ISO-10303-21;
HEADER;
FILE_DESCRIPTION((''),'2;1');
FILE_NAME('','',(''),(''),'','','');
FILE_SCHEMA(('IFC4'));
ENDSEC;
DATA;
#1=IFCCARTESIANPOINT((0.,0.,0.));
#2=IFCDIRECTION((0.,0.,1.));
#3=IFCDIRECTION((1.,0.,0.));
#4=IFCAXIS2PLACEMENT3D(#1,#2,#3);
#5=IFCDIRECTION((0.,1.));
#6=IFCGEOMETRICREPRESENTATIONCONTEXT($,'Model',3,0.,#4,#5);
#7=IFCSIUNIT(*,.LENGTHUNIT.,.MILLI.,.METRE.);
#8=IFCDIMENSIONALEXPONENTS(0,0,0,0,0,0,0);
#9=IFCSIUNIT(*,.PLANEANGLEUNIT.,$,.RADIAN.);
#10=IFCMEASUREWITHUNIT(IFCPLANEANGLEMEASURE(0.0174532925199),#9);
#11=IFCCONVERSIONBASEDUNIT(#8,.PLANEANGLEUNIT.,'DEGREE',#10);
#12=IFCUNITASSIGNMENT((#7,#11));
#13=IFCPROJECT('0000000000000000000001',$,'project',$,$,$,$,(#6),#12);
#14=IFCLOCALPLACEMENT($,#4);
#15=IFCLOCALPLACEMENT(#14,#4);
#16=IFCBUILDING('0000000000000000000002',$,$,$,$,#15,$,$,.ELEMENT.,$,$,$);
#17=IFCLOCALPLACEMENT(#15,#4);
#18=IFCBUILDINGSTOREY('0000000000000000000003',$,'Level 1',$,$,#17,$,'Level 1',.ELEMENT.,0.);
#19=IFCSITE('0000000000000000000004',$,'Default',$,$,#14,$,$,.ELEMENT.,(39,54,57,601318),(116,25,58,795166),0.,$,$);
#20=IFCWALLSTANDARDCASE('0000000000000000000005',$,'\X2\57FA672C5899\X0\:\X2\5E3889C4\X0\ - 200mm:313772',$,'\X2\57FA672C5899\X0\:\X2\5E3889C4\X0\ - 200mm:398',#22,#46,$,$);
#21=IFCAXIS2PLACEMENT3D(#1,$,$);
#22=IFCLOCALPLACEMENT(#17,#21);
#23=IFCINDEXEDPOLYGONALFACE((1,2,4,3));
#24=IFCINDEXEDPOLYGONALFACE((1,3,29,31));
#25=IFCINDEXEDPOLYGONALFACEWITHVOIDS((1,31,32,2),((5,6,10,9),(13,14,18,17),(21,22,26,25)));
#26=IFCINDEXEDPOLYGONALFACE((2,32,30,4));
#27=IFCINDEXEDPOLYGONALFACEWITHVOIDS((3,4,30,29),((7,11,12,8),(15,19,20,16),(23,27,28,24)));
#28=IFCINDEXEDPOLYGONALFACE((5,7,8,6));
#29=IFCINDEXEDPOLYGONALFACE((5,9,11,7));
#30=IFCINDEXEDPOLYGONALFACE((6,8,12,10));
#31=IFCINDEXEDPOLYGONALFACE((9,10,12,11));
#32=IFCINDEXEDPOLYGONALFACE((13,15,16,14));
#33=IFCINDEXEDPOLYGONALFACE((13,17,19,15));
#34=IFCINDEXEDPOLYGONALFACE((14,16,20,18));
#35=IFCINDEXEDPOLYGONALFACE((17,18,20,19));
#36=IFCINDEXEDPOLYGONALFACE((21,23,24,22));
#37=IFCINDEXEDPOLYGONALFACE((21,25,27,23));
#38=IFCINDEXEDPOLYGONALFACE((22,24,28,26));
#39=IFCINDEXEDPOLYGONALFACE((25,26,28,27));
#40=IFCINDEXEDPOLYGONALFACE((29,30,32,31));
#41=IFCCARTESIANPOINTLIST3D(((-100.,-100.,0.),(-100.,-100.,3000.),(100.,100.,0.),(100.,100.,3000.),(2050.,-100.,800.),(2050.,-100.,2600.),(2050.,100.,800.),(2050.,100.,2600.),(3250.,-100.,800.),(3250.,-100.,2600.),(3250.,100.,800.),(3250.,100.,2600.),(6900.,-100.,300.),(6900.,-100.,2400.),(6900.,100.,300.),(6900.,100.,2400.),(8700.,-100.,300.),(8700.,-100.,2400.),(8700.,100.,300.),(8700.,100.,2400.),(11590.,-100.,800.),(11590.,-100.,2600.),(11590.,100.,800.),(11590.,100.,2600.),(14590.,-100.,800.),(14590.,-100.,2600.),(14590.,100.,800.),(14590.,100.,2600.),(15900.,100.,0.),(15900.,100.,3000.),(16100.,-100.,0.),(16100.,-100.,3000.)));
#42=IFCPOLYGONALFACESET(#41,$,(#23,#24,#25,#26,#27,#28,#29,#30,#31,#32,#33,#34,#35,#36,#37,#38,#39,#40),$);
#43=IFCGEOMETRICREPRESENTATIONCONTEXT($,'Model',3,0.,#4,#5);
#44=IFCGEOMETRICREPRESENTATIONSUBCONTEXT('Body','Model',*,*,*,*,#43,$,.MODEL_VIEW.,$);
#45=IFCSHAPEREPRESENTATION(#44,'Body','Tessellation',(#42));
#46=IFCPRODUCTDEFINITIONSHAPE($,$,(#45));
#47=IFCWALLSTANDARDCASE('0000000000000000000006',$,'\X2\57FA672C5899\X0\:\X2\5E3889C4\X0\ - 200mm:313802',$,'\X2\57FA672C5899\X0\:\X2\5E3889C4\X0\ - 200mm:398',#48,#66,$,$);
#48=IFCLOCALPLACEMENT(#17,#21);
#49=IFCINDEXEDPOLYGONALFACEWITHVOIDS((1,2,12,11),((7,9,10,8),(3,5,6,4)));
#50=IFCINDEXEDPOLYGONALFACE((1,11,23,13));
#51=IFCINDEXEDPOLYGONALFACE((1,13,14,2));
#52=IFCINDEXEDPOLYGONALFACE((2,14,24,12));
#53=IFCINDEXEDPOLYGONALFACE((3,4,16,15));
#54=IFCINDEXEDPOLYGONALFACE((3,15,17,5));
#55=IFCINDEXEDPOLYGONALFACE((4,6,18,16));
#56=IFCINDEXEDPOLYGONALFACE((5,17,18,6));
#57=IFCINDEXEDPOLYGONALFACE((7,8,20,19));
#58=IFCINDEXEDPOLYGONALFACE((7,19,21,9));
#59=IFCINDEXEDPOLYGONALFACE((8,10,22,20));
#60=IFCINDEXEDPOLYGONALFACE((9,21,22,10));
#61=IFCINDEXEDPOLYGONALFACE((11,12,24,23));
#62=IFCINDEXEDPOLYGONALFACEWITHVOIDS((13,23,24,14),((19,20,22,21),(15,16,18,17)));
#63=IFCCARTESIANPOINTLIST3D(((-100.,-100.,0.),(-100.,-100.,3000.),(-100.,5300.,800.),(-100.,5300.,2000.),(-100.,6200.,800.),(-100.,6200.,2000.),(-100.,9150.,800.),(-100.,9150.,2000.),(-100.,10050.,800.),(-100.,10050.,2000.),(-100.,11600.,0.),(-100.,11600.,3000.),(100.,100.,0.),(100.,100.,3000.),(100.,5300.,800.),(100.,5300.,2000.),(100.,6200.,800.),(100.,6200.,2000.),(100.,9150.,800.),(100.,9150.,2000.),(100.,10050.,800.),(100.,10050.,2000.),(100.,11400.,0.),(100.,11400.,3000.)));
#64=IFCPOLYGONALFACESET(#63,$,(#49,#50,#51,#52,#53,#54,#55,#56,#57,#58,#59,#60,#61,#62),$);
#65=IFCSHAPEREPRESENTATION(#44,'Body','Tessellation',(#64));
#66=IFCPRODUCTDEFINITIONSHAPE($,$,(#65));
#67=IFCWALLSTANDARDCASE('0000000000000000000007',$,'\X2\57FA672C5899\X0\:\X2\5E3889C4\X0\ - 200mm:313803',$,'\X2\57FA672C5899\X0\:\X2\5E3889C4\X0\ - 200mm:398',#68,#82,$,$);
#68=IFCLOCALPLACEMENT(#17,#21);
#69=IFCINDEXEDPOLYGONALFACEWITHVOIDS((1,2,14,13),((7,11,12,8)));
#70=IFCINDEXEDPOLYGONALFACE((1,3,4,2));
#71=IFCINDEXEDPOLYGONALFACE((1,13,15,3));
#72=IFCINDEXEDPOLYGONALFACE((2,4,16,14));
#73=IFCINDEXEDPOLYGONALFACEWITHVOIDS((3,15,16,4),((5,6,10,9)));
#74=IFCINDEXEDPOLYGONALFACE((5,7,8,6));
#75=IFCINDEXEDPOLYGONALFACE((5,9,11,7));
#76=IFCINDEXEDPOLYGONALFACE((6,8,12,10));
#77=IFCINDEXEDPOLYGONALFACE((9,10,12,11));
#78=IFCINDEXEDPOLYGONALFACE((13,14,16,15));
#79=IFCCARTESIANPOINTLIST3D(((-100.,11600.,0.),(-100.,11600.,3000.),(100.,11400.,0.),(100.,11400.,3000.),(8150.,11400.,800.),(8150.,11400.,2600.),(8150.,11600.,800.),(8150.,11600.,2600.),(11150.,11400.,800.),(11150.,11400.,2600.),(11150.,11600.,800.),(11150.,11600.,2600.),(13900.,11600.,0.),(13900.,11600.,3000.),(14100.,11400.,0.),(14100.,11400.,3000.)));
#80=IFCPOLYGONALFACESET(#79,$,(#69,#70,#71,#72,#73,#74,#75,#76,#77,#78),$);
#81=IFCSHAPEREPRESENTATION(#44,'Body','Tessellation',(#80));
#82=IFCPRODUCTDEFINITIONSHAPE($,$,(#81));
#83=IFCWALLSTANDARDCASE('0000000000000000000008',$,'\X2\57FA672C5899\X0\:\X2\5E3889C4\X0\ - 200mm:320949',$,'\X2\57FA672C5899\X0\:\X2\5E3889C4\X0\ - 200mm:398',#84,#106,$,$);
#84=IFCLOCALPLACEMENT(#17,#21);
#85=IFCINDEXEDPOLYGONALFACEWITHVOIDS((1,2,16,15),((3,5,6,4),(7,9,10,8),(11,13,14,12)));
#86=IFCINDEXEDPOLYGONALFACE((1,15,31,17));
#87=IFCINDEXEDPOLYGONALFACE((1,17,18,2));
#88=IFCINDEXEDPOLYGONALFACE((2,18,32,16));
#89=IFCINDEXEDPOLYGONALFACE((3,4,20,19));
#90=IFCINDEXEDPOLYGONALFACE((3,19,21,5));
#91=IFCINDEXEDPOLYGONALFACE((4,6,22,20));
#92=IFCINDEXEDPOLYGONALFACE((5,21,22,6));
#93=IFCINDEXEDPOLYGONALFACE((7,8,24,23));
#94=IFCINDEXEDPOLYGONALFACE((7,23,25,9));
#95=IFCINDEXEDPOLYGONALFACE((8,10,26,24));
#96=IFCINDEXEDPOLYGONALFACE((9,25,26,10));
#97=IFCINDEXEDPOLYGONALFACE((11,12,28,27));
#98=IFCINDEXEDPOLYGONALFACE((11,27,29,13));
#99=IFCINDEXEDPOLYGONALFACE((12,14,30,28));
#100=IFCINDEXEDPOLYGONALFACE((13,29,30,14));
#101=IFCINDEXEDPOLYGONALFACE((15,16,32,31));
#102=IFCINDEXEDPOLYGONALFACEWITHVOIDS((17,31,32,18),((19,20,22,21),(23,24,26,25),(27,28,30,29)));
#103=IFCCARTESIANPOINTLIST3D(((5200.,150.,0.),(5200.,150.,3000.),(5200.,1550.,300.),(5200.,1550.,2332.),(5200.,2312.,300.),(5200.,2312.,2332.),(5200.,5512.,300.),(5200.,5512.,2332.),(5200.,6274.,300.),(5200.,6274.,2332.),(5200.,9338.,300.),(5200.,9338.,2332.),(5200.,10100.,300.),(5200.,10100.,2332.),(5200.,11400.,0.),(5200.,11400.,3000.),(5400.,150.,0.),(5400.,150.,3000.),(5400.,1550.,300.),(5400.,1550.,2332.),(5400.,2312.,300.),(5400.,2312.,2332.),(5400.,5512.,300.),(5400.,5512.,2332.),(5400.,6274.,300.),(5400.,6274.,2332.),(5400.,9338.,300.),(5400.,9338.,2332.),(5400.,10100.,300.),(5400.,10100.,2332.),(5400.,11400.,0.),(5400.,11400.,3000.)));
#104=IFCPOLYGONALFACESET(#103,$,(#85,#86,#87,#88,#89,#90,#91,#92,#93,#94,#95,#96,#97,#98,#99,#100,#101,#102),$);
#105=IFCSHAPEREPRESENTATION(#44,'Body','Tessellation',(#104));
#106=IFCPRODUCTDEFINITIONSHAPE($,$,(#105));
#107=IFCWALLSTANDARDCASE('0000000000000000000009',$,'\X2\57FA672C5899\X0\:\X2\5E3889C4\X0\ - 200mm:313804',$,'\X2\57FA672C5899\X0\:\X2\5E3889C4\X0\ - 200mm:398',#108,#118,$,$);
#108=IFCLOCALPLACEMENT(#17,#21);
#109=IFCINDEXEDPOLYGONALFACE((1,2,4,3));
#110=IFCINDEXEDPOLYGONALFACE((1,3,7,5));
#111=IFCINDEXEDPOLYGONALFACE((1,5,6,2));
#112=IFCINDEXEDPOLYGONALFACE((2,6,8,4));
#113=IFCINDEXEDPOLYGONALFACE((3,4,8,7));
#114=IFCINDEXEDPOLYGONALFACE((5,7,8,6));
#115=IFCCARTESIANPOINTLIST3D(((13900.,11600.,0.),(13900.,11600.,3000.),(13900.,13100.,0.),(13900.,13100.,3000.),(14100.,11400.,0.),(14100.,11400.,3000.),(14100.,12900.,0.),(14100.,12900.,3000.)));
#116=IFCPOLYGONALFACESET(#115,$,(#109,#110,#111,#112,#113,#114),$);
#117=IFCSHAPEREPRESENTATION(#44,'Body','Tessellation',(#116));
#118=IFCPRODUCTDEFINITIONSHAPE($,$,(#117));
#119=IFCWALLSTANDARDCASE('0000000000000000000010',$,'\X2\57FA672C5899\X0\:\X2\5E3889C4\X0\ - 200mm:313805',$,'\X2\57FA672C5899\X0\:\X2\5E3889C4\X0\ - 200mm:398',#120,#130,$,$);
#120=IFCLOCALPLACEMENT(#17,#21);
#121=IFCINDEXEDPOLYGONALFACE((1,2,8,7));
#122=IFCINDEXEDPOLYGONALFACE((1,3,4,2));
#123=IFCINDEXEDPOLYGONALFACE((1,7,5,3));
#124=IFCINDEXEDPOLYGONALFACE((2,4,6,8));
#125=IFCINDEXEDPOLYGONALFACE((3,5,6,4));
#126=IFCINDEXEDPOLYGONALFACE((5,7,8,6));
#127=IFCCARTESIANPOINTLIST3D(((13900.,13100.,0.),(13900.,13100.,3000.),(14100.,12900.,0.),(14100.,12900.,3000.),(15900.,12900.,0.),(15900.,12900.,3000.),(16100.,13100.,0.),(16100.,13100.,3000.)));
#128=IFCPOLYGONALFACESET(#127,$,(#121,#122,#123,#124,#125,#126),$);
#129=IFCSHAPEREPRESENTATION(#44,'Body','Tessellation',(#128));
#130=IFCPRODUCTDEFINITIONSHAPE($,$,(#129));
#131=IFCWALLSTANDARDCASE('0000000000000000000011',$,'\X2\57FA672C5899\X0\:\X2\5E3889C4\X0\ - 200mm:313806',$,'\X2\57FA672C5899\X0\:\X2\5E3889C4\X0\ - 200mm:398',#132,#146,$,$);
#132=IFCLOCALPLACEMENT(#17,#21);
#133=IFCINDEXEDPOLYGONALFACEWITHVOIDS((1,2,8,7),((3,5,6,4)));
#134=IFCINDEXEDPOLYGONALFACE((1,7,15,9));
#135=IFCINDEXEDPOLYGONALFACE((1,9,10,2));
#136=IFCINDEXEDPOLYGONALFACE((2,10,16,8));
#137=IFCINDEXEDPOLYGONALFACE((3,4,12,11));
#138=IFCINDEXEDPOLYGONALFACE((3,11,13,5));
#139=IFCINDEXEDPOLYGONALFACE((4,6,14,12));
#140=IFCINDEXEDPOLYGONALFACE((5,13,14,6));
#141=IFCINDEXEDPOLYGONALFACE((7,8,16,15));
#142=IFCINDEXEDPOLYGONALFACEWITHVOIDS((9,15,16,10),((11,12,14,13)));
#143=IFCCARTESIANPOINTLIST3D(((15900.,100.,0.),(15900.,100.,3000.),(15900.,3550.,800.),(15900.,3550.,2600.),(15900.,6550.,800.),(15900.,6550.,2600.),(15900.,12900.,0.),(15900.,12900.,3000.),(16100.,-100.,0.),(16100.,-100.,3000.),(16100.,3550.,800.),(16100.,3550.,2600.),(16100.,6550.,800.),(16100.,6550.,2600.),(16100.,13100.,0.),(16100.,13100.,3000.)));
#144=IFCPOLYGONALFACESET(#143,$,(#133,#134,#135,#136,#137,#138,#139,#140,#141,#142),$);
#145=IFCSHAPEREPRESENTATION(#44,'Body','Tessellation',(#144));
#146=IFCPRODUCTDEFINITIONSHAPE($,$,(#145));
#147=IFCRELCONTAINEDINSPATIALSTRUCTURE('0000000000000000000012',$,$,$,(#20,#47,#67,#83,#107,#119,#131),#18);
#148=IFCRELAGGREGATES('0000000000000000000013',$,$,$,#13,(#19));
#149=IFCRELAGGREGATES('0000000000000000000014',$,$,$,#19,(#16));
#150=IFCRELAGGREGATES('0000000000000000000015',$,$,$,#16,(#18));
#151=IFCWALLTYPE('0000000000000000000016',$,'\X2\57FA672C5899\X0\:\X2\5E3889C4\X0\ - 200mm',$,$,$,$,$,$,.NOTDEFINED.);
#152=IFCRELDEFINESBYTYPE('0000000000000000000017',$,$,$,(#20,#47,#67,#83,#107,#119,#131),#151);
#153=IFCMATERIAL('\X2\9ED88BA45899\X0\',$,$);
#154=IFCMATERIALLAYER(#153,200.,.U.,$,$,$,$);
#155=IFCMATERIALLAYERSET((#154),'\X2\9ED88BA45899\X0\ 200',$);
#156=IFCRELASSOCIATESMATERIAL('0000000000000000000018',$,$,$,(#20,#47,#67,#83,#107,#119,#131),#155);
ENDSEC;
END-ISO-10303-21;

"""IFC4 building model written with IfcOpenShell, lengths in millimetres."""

from ifc_helpers import new_model, entity, si_unit, converted_unit, direction, frame, origin_with_axes, place, context, subcontext, project, spatial, polyline, outline, extrude, material, layer, layer_set, layer_usage, type_object, element, save


model = new_model("IFC4")

# Units and contexts
model_context_1 = context("Model", 3, precision=0.0, world=origin_with_axes(), true_north=direction((0.0, 1.0)))
model_context_2 = context("Model", 3, precision=0.0, world=origin_with_axes(), true_north=direction((0.0, 1.0)))
body_context = subcontext(model_context_2, "Body", "Model", "MODEL_VIEW")
ifc_project = project(units=[si_unit("LENGTHUNIT", "METRE", prefix="MILLI"), converted_unit("PLANEANGLEUNIT", "DEGREE", entity("IfcPlaneAngleMeasure", 0.0174532925199), si_unit("PLANEANGLEUNIT", "RADIAN"), dimensions=[0, 0, 0, 0, 0, 0, 0])], contexts=[model_context_1])

# Site, building, storey
site_placement = place(None, origin_with_axes())
site = spatial("IfcSite", under=ifc_project, at=site_placement, Name="Default", CompositionType="ELEMENT", RefLatitude=(39, 54, 57, 601318), RefLongitude=(116, 25, 58, 795166), RefElevation=0.0)
building_placement = place(site_placement, origin_with_axes())
building = spatial("IfcBuilding", under=site, at=building_placement, CompositionType="ELEMENT")
storey_placement = place(building_placement, origin_with_axes())
storey = spatial("IfcBuildingStorey", under=building, at=storey_placement, Name="Level 1", LongName="Level 1", CompositionType="ELEMENT", Elevation=0.0)

# Walls, openings
ifc_material = material(Name="默认墙")
ifc_layer = layer(ifc_material, 200.0, ventilated="UNKNOWN")
ifc_layer_set = layer_set([ifc_layer], Name="默认墙 200")
ifc_layer_usage_1 = layer_usage(ifc_layer_set, "AXIS2", "POSITIVE", -100.0)
wall_type = type_object("IfcWallType", Name="基本墙:常规 - 200mm", PredefinedType="NOTDEFINED")
wall_1_placement = place(storey_placement, frame((16000.0, 0.0, 0.0), z_axis=(0.0, 0.0, 1.0), x_axis=(-1.0, 0.0, 0.0)))
wall_1 = element("IfcWallStandardCase", 1, at=wall_1_placement, inside=storey, type_object=wall_type, material=ifc_layer_usage_1, Name="基本墙:常规 - 200mm:313772", ObjectType="基本墙:常规 - 200mm:398", context=body_context, shape_type="SweptSolid", body=[
    extrude(outline(polyline([(100.0, -100.0), (15900.0, -100.0), (16100.0, 100.0), (-100.0, 100.0), (100.0, -100.0)])), origin_with_axes(), (0.0, 0.0, 1.0), 3000.0),
])
opening_1_placement = place(wall_1_placement, frame((13350.0, 0.0, 800.0), z_axis=(0.0, 0.0, 1.0), x_axis=(1.0, 0.0, 0.0)))
element("IfcOpeningElement", 2, at=opening_1_placement, cuts=wall_1, context=body_context, shape_type="SweptSolid", body=[
    extrude(outline(polyline([(-600.0, 0.0), (-600.0, -1800.0), (600.0, -1800.0), (600.0, 0.0), (-600.0, 0.0)])), frame((0.0, -100.0, 0.0), z_axis=(0.0, 1.0, 0.0), x_axis=(1.0, 0.0, 0.0)), (0.0, 0.0, 1.0), 200.0),
])
opening_2_placement = place(wall_1_placement, frame((2910.0, 0.0, 800.0), z_axis=(0.0, 0.0, 1.0), x_axis=(1.0, 0.0, 0.0)))
element("IfcOpeningElement", 3, at=opening_2_placement, cuts=wall_1, context=body_context, shape_type="SweptSolid", body=[
    extrude(outline(polyline([(-1500.0, 0.0), (-1500.0, -1800.0), (1500.0, -1800.0), (1500.0, 0.0), (-1500.0, 0.0)])), frame((0.0, -100.0, 0.0), z_axis=(0.0, 1.0, 0.0), x_axis=(1.0, 0.0, 0.0)), (0.0, 0.0, 1.0), 200.0),
])
opening_3_placement = place(wall_1_placement, frame((8200.0, 0.0, 300.0), z_axis=(0.0, 0.0, 1.0), x_axis=(1.0, 0.0, 0.0)))
element("IfcOpeningElement", 4, at=opening_3_placement, cuts=wall_1, context=body_context, shape_type="SweptSolid", body=[
    extrude(outline(polyline([(-900.0, 0.0), (-900.0, -2100.0), (900.0, -2100.0), (900.0, 0.0), (-900.0, 0.0)])), frame((0.0, -100.0, 0.0), z_axis=(0.0, 1.0, 0.0), x_axis=(1.0, 0.0, 0.0)), (0.0, 0.0, 1.0), 200.0),
])
ifc_layer_usage_2 = layer_usage(ifc_layer_set, "AXIS2", "POSITIVE", -100.0)
wall_2_placement = place(storey_placement, frame((0.0, 0.0, 0.0), z_axis=(0.0, 0.0, 1.0), x_axis=(0.0, 1.0, 0.0)))
wall_2 = element("IfcWallStandardCase", 5, at=wall_2_placement, inside=storey, type_object=wall_type, material=ifc_layer_usage_2, Name="基本墙:常规 - 200mm:313802", ObjectType="基本墙:常规 - 200mm:398", context=body_context, shape_type="SweptSolid", body=[
    extrude(outline(polyline([(100.0, -100.0), (11400.0, -100.0), (11600.0, 100.0), (-100.0, 100.0), (100.0, -100.0)])), origin_with_axes(), (0.0, 0.0, 1.0), 3000.0),
])
opening_4_placement = place(wall_2_placement, frame((5750.0, 0.0, 800.0), z_axis=(0.0, 0.0, 1.0), x_axis=(1.0, 0.0, 0.0)))
element("IfcOpeningElement", 6, at=opening_4_placement, cuts=wall_2, context=body_context, shape_type="SweptSolid", body=[
    extrude(outline(polyline([(450.0, -1200.0), (450.0, 0.0), (-450.0, 0.0), (-450.0, -1200.0), (450.0, -1200.0)])), frame((0.0, 100.0, 0.0), z_axis=(0.0, -1.0, 0.0), x_axis=(-1.0, 0.0, 0.0)), (0.0, 0.0, 1.0), 200.0),
])
opening_5_placement = place(wall_2_placement, frame((9600.0, 0.0, 800.0), z_axis=(0.0, 0.0, 1.0), x_axis=(1.0, 0.0, 0.0)))
element("IfcOpeningElement", 7, at=opening_5_placement, cuts=wall_2, context=body_context, shape_type="SweptSolid", body=[
    extrude(outline(polyline([(450.0, -1200.0), (450.0, 0.0), (-450.0, 0.0), (-450.0, -1200.0), (450.0, -1200.0)])), frame((0.0, 100.0, 0.0), z_axis=(0.0, -1.0, 0.0), x_axis=(-1.0, 0.0, 0.0)), (0.0, 0.0, 1.0), 200.0),
])

# Wall, opening
ifc_layer_usage_3 = layer_usage(ifc_layer_set, "AXIS2", "POSITIVE", -100.0)
wall_3_placement = place(storey_placement, frame((0.0, 11500.0, 0.0), z_axis=(0.0, 0.0, 1.0), x_axis=(1.0, 0.0, 0.0)))
wall_3 = element("IfcWallStandardCase", 8, at=wall_3_placement, inside=storey, type_object=wall_type, material=ifc_layer_usage_3, Name="基本墙:常规 - 200mm:313803", ObjectType="基本墙:常规 - 200mm:398", context=body_context, shape_type="SweptSolid", body=[
    extrude(outline(polyline([(100.0, -100.0), (14100.0, -100.0), (13900.0, 100.0), (-100.0, 100.0), (100.0, -100.0)])), origin_with_axes(), (0.0, 0.0, 1.0), 3000.0),
])
opening_6_placement = place(wall_3_placement, frame((9650.0, 0.0, 800.0), z_axis=(0.0, 0.0, 1.0), x_axis=(1.0, 0.0, 0.0)))
element("IfcOpeningElement", 9, at=opening_6_placement, cuts=wall_3, context=body_context, shape_type="SweptSolid", body=[
    extrude(outline(polyline([(-1500.0, 0.0), (-1500.0, -1800.0), (1500.0, -1800.0), (1500.0, 0.0), (-1500.0, 0.0)])), frame((0.0, -100.0, 0.0), z_axis=(0.0, 1.0, 0.0), x_axis=(1.0, 0.0, 0.0)), (0.0, 0.0, 1.0), 200.0),
])

# Wall, openings
ifc_layer_usage_4 = layer_usage(ifc_layer_set, "AXIS2", "POSITIVE", -100.0)
wall_4_placement = place(storey_placement, frame((5300.0, 11500.0, 0.0), z_axis=(0.0, 0.0, 1.0), x_axis=(0.0, -1.0, 0.0)))
wall_4 = element("IfcWallStandardCase", 10, at=wall_4_placement, inside=storey, type_object=wall_type, material=ifc_layer_usage_4, Name="基本墙:常规 - 200mm:320949", ObjectType="基本墙:常规 - 200mm:398", context=body_context, shape_type="SweptSolid", body=[
    extrude(outline(polyline([(100.0, -100.0), (11350.0, -100.0), (11350.0, 100.0), (100.0, 100.0), (100.0, -100.0)])), origin_with_axes(), (0.0, 0.0, 1.0), 3000.0),
])
opening_7_placement = place(wall_4_placement, frame((9569.0, 0.0, 300.0), z_axis=(0.0, 0.0, 1.0), x_axis=(1.0, 0.0, 0.0)))
element("IfcOpeningElement", 11, at=opening_7_placement, cuts=wall_4, context=body_context, shape_type="SweptSolid", body=[
    extrude(outline(polyline([(-381.0, -2032.0), (381.0, -2032.0), (381.0, 0.0), (-381.0, 0.0), (-381.0, -2032.0)])), frame((0.0, -100.0, 0.0), z_axis=(0.0, 1.0, 0.0), x_axis=(1.0, 0.0, 0.0)), (0.0, 0.0, 1.0), 200.0),
])
opening_8_placement = place(wall_4_placement, frame((5607.0, 0.0, 300.0), z_axis=(0.0, 0.0, 1.0), x_axis=(1.0, 0.0, 0.0)))
element("IfcOpeningElement", 12, at=opening_8_placement, cuts=wall_4, context=body_context, shape_type="SweptSolid", body=[
    extrude(outline(polyline([(-381.0, -2032.0), (381.0, -2032.0), (381.0, 0.0), (-381.0, 0.0), (-381.0, -2032.0)])), frame((0.0, -100.0, 0.0), z_axis=(0.0, 1.0, 0.0), x_axis=(1.0, 0.0, 0.0)), (0.0, 0.0, 1.0), 200.0),
])
opening_9_placement = place(wall_4_placement, frame((1781.0, 0.0, 300.0), z_axis=(0.0, 0.0, 1.0), x_axis=(1.0, 0.0, 0.0)))
element("IfcOpeningElement", 13, at=opening_9_placement, cuts=wall_4, context=body_context, shape_type="SweptSolid", body=[
    extrude(outline(polyline([(-381.0, -2032.0), (381.0, -2032.0), (381.0, 0.0), (-381.0, 0.0), (-381.0, -2032.0)])), frame((0.0, -100.0, 0.0), z_axis=(0.0, 1.0, 0.0), x_axis=(1.0, 0.0, 0.0)), (0.0, 0.0, 1.0), 200.0),
])

# Walls
ifc_layer_usage_5 = layer_usage(ifc_layer_set, "AXIS2", "POSITIVE", -100.0)
wall_5_placement = place(storey_placement, frame((14000.0, 11500.0, 0.0), z_axis=(0.0, 0.0, 1.0), x_axis=(0.0, 1.0, 0.0)))
element("IfcWallStandardCase", 14, at=wall_5_placement, inside=storey, type_object=wall_type, material=ifc_layer_usage_5, Name="基本墙:常规 - 200mm:313804", ObjectType="基本墙:常规 - 200mm:398", context=body_context, shape_type="SweptSolid", body=[
    extrude(outline(polyline([(-100.0, -100.0), (1400.0, -100.0), (1600.0, 100.0), (100.0, 100.0), (-100.0, -100.0)])), origin_with_axes(), (0.0, 0.0, 1.0), 3000.0),
])
ifc_layer_usage_6 = layer_usage(ifc_layer_set, "AXIS2", "POSITIVE", -100.0)
wall_6_placement = place(storey_placement, frame((14000.0, 13000.0, 0.0), z_axis=(0.0, 0.0, 1.0), x_axis=(1.0, 0.0, 0.0)))
element("IfcWallStandardCase", 15, at=wall_6_placement, inside=storey, type_object=wall_type, material=ifc_layer_usage_6, Name="基本墙:常规 - 200mm:313805", ObjectType="基本墙:常规 - 200mm:398", context=body_context, shape_type="SweptSolid", body=[
    extrude(outline(polyline([(100.0, -100.0), (1900.0, -100.0), (2100.0, 100.0), (-100.0, 100.0), (100.0, -100.0)])), origin_with_axes(), (0.0, 0.0, 1.0), 3000.0),
])

# Wall, opening
ifc_layer_usage_7 = layer_usage(ifc_layer_set, "AXIS2", "POSITIVE", -100.0)
wall_7_placement = place(storey_placement, frame((16000.0, 13000.0, 0.0), z_axis=(0.0, 0.0, 1.0), x_axis=(0.0, -1.0, 0.0)))
wall_7 = element("IfcWallStandardCase", 16, at=wall_7_placement, inside=storey, type_object=wall_type, material=ifc_layer_usage_7, Name="基本墙:常规 - 200mm:313806", ObjectType="基本墙:常规 - 200mm:398", context=body_context, shape_type="SweptSolid", body=[
    extrude(outline(polyline([(100.0, -100.0), (12900.0, -100.0), (13100.0, 100.0), (-100.0, 100.0), (100.0, -100.0)])), origin_with_axes(), (0.0, 0.0, 1.0), 3000.0),
])
opening_10_placement = place(wall_7_placement, frame((7950.0, 0.0, 800.0), z_axis=(0.0, 0.0, 1.0), x_axis=(1.0, 0.0, 0.0)))
element("IfcOpeningElement", 17, at=opening_10_placement, cuts=wall_7, context=body_context, shape_type="SweptSolid", body=[
    extrude(outline(polyline([(-1500.0, 0.0), (-1500.0, -1800.0), (1500.0, -1800.0), (1500.0, 0.0), (-1500.0, 0.0)])), frame((0.0, -100.0, 0.0), z_axis=(0.0, 1.0, 0.0), x_axis=(1.0, 0.0, 0.0)), (0.0, 0.0, 1.0), 200.0),
])

save(model, "model.ifc")
